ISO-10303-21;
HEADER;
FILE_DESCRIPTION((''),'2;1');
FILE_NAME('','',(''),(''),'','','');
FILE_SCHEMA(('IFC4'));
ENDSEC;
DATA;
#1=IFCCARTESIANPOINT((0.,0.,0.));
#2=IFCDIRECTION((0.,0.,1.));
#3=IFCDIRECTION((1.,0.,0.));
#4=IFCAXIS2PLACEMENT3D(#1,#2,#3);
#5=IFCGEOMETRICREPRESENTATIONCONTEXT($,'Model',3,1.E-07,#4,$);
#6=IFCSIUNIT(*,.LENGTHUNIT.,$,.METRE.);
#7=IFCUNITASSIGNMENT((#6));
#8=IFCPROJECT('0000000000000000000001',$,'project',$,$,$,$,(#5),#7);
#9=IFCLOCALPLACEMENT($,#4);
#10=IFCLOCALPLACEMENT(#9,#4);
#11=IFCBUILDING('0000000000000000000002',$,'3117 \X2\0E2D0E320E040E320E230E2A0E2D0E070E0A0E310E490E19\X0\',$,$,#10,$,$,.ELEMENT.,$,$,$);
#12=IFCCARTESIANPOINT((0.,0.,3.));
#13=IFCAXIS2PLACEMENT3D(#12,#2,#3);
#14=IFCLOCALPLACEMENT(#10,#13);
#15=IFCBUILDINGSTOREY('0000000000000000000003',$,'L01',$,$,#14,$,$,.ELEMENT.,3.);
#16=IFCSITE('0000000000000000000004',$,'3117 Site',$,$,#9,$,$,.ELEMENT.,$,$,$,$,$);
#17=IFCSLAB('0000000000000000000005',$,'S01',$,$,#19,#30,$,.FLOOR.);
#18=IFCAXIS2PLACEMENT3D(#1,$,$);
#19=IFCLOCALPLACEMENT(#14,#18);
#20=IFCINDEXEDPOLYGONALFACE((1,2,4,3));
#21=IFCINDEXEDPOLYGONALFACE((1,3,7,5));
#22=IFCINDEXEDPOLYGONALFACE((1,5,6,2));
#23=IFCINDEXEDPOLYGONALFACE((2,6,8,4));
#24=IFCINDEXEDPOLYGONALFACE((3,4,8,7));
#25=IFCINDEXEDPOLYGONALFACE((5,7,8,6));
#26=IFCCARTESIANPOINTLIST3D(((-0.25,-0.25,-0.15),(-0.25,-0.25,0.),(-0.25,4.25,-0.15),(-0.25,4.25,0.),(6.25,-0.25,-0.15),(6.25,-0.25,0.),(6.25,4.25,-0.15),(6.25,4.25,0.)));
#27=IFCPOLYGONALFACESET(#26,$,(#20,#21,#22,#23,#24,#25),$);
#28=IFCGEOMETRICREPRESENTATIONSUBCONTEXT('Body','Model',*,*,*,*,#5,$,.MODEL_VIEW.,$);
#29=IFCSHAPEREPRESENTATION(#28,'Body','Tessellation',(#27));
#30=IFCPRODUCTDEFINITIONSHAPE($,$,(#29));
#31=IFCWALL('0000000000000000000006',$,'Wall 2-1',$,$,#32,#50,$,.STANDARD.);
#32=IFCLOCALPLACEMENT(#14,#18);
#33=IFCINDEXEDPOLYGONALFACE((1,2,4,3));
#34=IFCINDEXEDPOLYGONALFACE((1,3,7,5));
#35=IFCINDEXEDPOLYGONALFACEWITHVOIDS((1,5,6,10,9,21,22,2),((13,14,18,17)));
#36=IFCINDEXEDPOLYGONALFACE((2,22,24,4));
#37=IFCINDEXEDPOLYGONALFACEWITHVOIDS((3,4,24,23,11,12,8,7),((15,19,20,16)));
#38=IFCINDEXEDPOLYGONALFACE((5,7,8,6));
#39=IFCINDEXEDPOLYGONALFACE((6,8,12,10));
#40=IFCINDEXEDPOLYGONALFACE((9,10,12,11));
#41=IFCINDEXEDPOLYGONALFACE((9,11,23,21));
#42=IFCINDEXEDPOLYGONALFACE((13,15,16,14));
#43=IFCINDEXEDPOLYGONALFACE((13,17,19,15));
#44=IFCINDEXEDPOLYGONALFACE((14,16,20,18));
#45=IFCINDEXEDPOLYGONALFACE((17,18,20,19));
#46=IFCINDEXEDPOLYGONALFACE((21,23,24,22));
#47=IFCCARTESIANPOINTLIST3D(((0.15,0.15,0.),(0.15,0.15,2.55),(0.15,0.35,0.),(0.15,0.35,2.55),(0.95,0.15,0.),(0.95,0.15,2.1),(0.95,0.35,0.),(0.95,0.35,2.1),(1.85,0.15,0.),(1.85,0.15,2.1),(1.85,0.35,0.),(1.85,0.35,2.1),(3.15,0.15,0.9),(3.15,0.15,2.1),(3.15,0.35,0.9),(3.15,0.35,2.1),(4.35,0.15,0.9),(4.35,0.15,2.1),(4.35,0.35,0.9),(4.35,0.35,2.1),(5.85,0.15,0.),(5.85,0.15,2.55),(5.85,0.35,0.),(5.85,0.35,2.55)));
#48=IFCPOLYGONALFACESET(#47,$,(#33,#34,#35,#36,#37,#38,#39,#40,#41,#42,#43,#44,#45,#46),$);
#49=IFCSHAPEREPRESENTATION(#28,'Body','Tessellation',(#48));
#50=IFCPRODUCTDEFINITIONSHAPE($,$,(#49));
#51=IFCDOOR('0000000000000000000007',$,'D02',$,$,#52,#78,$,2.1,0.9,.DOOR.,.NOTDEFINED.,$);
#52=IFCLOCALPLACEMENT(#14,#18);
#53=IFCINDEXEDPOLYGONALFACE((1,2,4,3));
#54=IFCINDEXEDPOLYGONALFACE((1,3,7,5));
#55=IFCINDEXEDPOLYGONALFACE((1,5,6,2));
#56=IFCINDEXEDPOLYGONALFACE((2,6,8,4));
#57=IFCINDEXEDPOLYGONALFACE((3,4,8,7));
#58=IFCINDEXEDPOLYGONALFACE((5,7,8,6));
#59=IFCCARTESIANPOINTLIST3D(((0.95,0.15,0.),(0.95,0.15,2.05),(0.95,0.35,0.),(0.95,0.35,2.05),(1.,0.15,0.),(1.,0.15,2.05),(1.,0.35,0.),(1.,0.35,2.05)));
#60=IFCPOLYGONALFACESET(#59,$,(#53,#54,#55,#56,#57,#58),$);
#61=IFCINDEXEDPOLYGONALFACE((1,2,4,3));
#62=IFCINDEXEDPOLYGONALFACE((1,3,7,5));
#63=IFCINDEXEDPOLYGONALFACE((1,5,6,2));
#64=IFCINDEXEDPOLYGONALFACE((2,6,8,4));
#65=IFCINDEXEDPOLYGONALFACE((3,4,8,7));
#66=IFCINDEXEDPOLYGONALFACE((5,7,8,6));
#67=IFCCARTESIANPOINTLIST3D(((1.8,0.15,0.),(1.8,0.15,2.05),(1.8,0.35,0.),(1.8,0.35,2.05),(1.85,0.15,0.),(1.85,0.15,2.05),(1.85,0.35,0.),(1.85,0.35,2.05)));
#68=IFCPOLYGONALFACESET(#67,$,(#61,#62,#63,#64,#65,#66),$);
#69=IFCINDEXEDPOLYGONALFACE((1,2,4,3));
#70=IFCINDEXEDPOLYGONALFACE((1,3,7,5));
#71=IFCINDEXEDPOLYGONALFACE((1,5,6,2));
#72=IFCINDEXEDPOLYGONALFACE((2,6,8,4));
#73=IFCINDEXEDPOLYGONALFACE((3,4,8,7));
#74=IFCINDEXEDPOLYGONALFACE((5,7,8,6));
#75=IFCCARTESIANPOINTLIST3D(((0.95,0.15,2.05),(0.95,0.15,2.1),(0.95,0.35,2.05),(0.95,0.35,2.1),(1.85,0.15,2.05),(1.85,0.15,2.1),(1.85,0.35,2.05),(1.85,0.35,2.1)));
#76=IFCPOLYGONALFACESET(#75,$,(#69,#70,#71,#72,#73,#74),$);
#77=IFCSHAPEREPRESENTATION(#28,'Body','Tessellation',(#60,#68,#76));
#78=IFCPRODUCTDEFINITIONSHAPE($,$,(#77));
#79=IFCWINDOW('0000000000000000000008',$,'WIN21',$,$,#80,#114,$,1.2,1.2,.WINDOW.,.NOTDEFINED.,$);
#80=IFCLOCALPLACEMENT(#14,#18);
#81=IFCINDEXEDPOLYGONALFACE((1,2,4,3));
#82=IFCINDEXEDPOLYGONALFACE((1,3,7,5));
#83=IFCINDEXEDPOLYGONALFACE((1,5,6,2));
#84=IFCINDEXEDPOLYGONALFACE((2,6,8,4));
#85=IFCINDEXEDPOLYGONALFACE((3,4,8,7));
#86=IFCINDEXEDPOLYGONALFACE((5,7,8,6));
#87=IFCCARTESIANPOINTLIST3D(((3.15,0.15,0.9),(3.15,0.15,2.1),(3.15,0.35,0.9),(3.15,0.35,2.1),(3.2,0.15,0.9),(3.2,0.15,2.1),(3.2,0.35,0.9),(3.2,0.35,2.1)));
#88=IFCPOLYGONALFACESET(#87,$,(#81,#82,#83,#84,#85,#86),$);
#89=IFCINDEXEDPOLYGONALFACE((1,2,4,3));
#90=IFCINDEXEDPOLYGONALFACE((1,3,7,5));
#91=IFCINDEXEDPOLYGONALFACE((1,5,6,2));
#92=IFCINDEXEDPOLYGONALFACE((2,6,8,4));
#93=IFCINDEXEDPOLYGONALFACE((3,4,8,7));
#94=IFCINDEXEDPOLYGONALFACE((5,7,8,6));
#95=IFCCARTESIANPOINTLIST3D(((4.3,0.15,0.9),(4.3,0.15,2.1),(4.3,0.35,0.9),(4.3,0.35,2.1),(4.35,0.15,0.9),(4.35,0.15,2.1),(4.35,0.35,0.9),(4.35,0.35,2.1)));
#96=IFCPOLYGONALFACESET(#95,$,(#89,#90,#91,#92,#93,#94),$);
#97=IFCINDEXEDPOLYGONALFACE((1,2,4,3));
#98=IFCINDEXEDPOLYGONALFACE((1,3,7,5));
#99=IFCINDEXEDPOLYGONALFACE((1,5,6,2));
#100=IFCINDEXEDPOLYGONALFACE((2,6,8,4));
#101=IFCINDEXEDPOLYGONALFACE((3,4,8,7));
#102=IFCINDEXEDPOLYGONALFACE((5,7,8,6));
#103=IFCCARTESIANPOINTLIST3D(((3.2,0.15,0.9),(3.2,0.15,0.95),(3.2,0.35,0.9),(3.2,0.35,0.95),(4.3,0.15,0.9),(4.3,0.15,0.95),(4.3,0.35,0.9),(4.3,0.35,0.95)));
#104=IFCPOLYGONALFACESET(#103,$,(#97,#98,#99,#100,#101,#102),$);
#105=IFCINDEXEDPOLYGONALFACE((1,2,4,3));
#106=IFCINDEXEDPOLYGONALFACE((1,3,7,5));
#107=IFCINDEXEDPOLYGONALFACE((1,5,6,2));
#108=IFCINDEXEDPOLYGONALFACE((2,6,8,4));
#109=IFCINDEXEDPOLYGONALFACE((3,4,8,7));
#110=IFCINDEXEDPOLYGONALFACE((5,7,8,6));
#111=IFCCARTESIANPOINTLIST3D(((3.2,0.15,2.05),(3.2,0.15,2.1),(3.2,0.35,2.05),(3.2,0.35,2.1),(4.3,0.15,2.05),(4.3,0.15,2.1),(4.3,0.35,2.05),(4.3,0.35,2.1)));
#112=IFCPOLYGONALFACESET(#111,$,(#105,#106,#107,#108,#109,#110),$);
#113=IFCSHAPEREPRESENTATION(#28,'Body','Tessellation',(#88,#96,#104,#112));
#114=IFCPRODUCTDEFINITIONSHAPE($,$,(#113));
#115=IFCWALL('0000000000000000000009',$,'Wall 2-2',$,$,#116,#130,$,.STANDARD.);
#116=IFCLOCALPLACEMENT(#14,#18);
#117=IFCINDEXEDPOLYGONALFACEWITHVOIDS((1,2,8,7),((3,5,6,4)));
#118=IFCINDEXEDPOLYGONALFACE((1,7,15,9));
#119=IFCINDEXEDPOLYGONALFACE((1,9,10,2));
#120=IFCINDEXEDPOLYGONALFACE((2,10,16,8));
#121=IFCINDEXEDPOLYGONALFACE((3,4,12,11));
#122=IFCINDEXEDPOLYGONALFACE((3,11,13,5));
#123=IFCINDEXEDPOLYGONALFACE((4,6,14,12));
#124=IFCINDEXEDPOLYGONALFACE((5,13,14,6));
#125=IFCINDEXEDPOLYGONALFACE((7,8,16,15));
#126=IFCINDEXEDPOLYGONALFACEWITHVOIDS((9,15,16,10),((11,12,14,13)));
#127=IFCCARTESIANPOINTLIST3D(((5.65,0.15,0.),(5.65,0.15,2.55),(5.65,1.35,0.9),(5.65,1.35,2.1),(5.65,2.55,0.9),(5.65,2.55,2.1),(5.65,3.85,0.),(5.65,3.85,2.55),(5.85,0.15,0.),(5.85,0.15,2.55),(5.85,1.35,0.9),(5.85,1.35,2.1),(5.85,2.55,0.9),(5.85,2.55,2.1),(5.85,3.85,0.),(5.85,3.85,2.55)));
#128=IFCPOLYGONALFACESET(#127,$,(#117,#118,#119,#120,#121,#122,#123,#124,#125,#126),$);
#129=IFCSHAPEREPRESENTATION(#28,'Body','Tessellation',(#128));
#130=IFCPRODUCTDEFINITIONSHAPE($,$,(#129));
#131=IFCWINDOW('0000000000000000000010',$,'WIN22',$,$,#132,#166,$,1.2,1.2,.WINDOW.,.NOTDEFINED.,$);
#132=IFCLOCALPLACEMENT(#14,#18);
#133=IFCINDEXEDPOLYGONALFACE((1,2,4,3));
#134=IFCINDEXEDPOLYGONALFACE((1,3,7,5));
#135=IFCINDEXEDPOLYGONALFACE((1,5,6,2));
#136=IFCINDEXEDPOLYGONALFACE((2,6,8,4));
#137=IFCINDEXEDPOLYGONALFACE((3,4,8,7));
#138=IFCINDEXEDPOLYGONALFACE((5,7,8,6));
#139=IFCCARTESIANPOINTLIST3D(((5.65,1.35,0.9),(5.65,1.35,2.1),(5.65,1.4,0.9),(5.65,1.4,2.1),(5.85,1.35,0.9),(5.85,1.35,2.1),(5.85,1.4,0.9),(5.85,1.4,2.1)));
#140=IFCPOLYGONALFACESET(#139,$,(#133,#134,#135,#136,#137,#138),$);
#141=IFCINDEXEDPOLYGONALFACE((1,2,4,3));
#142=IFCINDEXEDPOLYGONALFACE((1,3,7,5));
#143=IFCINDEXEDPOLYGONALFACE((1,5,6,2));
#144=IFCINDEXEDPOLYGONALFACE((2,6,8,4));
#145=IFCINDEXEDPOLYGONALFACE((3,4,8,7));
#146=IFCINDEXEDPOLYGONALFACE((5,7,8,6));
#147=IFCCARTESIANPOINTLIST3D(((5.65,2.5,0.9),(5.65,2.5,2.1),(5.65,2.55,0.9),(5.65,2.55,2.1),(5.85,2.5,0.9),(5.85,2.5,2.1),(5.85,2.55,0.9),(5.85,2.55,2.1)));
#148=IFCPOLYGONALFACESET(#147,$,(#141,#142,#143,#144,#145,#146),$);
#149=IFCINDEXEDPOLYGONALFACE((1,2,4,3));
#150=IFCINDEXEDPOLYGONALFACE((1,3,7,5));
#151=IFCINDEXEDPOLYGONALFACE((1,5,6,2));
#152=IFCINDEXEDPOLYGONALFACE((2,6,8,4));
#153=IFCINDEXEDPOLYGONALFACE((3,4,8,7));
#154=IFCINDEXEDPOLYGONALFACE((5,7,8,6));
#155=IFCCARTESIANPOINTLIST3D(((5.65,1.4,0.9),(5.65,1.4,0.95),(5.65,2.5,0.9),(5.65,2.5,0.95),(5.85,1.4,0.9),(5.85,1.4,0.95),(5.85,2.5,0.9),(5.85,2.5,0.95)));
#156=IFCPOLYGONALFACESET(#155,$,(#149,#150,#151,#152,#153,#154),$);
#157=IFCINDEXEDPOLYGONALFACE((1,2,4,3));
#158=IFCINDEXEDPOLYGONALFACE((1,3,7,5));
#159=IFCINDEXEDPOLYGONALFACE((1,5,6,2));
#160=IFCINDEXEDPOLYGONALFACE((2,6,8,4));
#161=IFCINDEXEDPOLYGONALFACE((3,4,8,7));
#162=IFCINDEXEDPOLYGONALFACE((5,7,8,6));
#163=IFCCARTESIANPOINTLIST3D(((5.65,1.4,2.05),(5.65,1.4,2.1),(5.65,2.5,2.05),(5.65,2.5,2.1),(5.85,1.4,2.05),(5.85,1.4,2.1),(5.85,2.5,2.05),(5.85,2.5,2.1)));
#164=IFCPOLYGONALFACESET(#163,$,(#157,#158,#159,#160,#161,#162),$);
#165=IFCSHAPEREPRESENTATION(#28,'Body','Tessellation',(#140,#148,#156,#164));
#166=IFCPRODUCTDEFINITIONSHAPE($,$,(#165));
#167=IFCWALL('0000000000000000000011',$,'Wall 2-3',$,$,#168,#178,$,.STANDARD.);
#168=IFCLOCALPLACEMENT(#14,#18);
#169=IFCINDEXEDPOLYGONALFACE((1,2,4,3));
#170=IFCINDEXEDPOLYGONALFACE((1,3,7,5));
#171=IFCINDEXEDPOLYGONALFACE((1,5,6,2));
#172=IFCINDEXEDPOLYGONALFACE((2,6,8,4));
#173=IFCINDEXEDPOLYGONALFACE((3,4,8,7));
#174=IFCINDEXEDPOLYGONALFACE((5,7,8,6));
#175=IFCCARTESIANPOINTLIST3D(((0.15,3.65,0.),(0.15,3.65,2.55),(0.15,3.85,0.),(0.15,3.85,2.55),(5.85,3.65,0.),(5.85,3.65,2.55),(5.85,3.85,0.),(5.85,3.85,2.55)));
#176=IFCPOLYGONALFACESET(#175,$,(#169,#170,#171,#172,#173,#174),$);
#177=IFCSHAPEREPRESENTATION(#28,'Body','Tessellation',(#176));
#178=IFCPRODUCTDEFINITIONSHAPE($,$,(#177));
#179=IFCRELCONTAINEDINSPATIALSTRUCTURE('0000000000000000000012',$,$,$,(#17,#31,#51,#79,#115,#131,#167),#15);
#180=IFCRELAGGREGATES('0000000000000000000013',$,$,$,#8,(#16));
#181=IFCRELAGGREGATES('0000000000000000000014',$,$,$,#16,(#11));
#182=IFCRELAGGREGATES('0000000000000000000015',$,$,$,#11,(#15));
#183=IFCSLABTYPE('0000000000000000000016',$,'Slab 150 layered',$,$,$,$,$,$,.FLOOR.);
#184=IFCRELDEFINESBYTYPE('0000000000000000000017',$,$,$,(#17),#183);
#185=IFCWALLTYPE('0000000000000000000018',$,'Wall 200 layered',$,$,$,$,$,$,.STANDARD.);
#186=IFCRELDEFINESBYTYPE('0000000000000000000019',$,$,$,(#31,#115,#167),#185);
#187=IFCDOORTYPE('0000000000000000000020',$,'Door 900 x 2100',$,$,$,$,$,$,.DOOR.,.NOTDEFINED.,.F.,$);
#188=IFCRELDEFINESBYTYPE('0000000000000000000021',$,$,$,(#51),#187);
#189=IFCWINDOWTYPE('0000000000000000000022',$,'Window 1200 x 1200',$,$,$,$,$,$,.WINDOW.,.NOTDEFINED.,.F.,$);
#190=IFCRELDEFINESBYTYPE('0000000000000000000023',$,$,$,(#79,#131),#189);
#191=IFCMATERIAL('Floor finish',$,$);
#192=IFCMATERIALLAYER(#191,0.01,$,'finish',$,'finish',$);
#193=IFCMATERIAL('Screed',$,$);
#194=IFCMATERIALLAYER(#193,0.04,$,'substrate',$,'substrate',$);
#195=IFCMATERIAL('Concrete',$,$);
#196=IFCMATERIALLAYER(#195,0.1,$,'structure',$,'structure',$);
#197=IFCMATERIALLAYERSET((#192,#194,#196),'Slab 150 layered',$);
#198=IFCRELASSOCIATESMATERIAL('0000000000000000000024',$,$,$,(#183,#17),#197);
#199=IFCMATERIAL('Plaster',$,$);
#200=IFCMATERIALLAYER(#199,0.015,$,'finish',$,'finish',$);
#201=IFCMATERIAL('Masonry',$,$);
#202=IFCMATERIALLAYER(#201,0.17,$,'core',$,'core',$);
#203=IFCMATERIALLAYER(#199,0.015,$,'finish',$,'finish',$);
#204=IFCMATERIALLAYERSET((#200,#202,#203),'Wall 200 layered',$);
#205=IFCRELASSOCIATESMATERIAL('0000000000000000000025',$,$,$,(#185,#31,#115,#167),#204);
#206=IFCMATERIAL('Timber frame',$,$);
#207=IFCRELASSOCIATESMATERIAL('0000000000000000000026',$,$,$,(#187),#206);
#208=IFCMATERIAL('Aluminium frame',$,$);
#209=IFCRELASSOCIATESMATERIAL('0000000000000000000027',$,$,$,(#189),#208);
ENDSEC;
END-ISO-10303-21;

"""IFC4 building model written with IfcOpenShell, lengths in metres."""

from ifc_helpers import new_model, si_unit, frame, origin_with_axes, place, context, subcontext, project, spatial, polyline, outline, extrude, material, layer, layer_set, layer_usage, type_object, element, fill, save


model = new_model("IFC4")

# Units and contexts
model_context = context("Model", 3, precision=1e-07, world=origin_with_axes())
body_context = subcontext(model_context, "Body", "Model", "MODEL_VIEW")
ifc_project = project(units=[si_unit("LENGTHUNIT", "METRE")], contexts=[model_context])

# Site, building, storey
site_placement = place(None, origin_with_axes())
site = spatial("IfcSite", under=ifc_project, at=site_placement, Name="3117 Site", CompositionType="ELEMENT")
building_placement = place(site_placement, origin_with_axes())
building = spatial("IfcBuilding", under=site, at=building_placement, Name="3117 อาคารสองชั้น", CompositionType="ELEMENT")
storey_placement = place(building_placement, frame((0.0, 0.0, 3.0), z_axis=(0.0, 0.0, 1.0), x_axis=(1.0, 0.0, 0.0)))
storey = spatial("IfcBuildingStorey", under=building, at=storey_placement, Name="L01", CompositionType="ELEMENT", Elevation=3.0)

# Shared definitions
ifc_material_1 = material(Name="Concrete")

# Slab
ifc_material_2 = material(Name="Floor finish")
ifc_layer_1 = layer(ifc_material_2, 0.01, Name="finish", Category="finish")
ifc_material_3 = material(Name="Screed")
ifc_layer_2 = layer(ifc_material_3, 0.04, Name="substrate", Category="substrate")
ifc_layer_3 = layer(ifc_material_1, 0.1, Name="structure", Category="structure")
ifc_layer_set_1 = layer_set([ifc_layer_1, ifc_layer_2, ifc_layer_3], Name="Slab 150 layered")
ifc_layer_usage_1 = layer_usage(ifc_layer_set_1, "AXIS3", "NEGATIVE", 0.15)
slab_type = type_object("IfcSlabType", Name="Slab 150 layered", PredefinedType="FLOOR", material=ifc_layer_set_1)
slab_placement = place(storey_placement, frame((0.0, 0.0, -0.15), z_axis=(0.0, 0.0, 1.0), x_axis=(1.0, 0.0, 0.0)))
element("IfcSlab", 1, at=slab_placement, inside=storey, type_object=slab_type, material=ifc_layer_usage_1, Name="S01", PredefinedType="FLOOR", context=body_context, shape_type="SweptSolid", body=[
    extrude(outline(polyline([(-0.25, -0.25), (6.25, -0.25), (6.25, 4.25), (-0.25, 4.25), (-0.25, -0.25)])), origin_with_axes(), (0.0, 0.0, 1.0), 0.15),
])

# Wall, openings, door, window
ifc_material_4 = material(Name="Plaster")
ifc_layer_4 = layer(ifc_material_4, 0.015, Name="finish", Category="finish")
ifc_material_5 = material(Name="Masonry")
ifc_layer_5 = layer(ifc_material_5, 0.17, Name="core", Category="core")
ifc_layer_6 = layer(ifc_material_4, 0.015, Name="finish", Category="finish")
ifc_layer_set_2 = layer_set([ifc_layer_4, ifc_layer_5, ifc_layer_6], Name="Wall 200 layered")
ifc_layer_usage_2 = layer_usage(ifc_layer_set_2, "AXIS2", "POSITIVE", 0.0)
wall_type = type_object("IfcWallType", Name="Wall 200 layered", PredefinedType="STANDARD", material=ifc_layer_set_2)
wall_1_placement = place(storey_placement, frame((0.15, 0.15, 0.0), z_axis=(0.0, 0.0, 1.0), x_axis=(1.0, 0.0, 0.0)))
wall_1 = element("IfcWall", 2, at=wall_1_placement, inside=storey, type_object=wall_type, material=ifc_layer_usage_2, Name="Wall 2-1", PredefinedType="STANDARD", context=body_context, shape_type="SweptSolid", body=[
    extrude(outline(polyline([(0.0, 0.0), (5.7, 0.0), (5.7, 0.2), (0.0, 0.2), (0.0, 0.0)])), origin_with_axes(), (0.0, 0.0, 1.0), 2.55),
])
opening_1_placement = place(wall_1_placement, frame((3.0, 0.0, 0.9), z_axis=(0.0, 0.0, 1.0), x_axis=(1.0, 0.0, 0.0)))
opening_1 = element("IfcOpeningElement", 3, at=opening_1_placement, cuts=wall_1, PredefinedType="OPENING", context=body_context, shape_type="SweptSolid", body=[
    extrude(outline(polyline([(0.0, 0.0), (1.2, 0.0), (1.2, 0.2), (0.0, 0.2), (0.0, 0.0)])), origin_with_axes(), (0.0, 0.0, 1.0), 1.2),
])
opening_2_placement = place(wall_1_placement, frame((0.8, 0.0, 0.0), z_axis=(0.0, 0.0, 1.0), x_axis=(1.0, 0.0, 0.0)))
opening_2 = element("IfcOpeningElement", 4, at=opening_2_placement, cuts=wall_1, PredefinedType="OPENING", context=body_context, shape_type="SweptSolid", body=[
    extrude(outline(polyline([(0.0, 0.0), (0.9, 0.0), (0.9, 0.2), (0.0, 0.2), (0.0, 0.0)])), origin_with_axes(), (0.0, 0.0, 1.0), 2.1),
])
ifc_material_6 = material(Name="Timber frame")
door_type = type_object("IfcDoorType", Name="Door 900 x 2100", OperationType="NOTDEFINED", ParameterTakesPrecedence=False, PredefinedType="DOOR", material=ifc_material_6)
door_placement = place(opening_2_placement, frame((0.0, 0.0, 0.0), z_axis=(0.0, 0.0, 1.0), x_axis=(1.0, 0.0, 0.0)))
door = element("IfcDoor", 5, at=door_placement, inside=storey, type_object=door_type, Name="D02", OperationType="NOTDEFINED", OverallHeight=2.1, OverallWidth=0.9, PredefinedType="DOOR", context=body_context, shape_type="SweptSolid", body=[
    extrude(outline(polyline([(0.0, 0.0), (0.05, 0.0), (0.05, 0.2), (0.0, 0.2), (0.0, 0.0)])), origin_with_axes(), (0.0, 0.0, 1.0), 2.05),
    extrude(outline(polyline([(0.0, 0.0), (0.05, 0.0), (0.05, 0.2), (0.0, 0.2), (0.0, 0.0)])), frame((0.85, 0.0, 0.0), z_axis=(0.0, 0.0, 1.0), x_axis=(1.0, 0.0, 0.0)), (0.0, 0.0, 1.0), 2.05),
    extrude(outline(polyline([(0.0, 0.0), (0.9, 0.0), (0.9, 0.2), (0.0, 0.2), (0.0, 0.0)])), frame((0.0, 0.0, 2.05), z_axis=(0.0, 0.0, 1.0), x_axis=(1.0, 0.0, 0.0)), (0.0, 0.0, 1.0), 0.05),
])
fill(opening_2, door)
ifc_material_7 = material(Name="Aluminium frame")
window_type = type_object("IfcWindowType", Name="Window 1200 x 1200", ParameterTakesPrecedence=False, PartitioningType="NOTDEFINED", PredefinedType="WINDOW", material=ifc_material_7)
window_1_placement = place(opening_1_placement, frame((0.0, 0.0, 0.0), z_axis=(0.0, 0.0, 1.0), x_axis=(1.0, 0.0, 0.0)))
window_1 = element("IfcWindow", 6, at=window_1_placement, inside=storey, type_object=window_type, Name="WIN21", OverallHeight=1.2, OverallWidth=1.2, PartitioningType="NOTDEFINED", PredefinedType="WINDOW", context=body_context, shape_type="SweptSolid", body=[
    extrude(outline(polyline([(0.0, 0.0), (0.05, 0.0), (0.05, 0.2), (0.0, 0.2), (0.0, 0.0)])), origin_with_axes(), (0.0, 0.0, 1.0), 1.2),
    extrude(outline(polyline([(0.0, 0.0), (0.05, 0.0), (0.05, 0.2), (0.0, 0.2), (0.0, 0.0)])), frame((1.15, 0.0, 0.0), z_axis=(0.0, 0.0, 1.0), x_axis=(1.0, 0.0, 0.0)), (0.0, 0.0, 1.0), 1.2),
    extrude(outline(polyline([(0.0, 0.0), (1.1, 0.0), (1.1, 0.2), (0.0, 0.2), (0.0, 0.0)])), frame((0.05, 0.0, 0.0), z_axis=(0.0, 0.0, 1.0), x_axis=(1.0, 0.0, 0.0)), (0.0, 0.0, 1.0), 0.05),
    extrude(outline(polyline([(0.0, 0.0), (1.1, 0.0), (1.1, 0.2), (0.0, 0.2), (0.0, 0.0)])), frame((0.05, 0.0, 1.15), z_axis=(0.0, 0.0, 1.0), x_axis=(1.0, 0.0, 0.0)), (0.0, 0.0, 1.0), 0.05),
])
fill(opening_1, window_1)

# Wall, opening, window
ifc_layer_usage_3 = layer_usage(ifc_layer_set_2, "AXIS2", "POSITIVE", 0.0)
wall_2_placement = place(storey_placement, frame((5.85, 0.15, 0.0), z_axis=(0.0, 0.0, 1.0), x_axis=(0.0, 1.0, 0.0)))
wall_2 = element("IfcWall", 7, at=wall_2_placement, inside=storey, type_object=wall_type, material=ifc_layer_usage_3, Name="Wall 2-2", PredefinedType="STANDARD", context=body_context, shape_type="SweptSolid", body=[
    extrude(outline(polyline([(0.0, 0.0), (3.7, 0.0), (3.7, 0.2), (0.0, 0.2), (0.0, 0.0)])), origin_with_axes(), (0.0, 0.0, 1.0), 2.55),
])
opening_3_placement = place(wall_2_placement, frame((1.2, 0.0, 0.9), z_axis=(0.0, 0.0, 1.0), x_axis=(1.0, 0.0, 0.0)))
opening_3 = element("IfcOpeningElement", 8, at=opening_3_placement, cuts=wall_2, PredefinedType="OPENING", context=body_context, shape_type="SweptSolid", body=[
    extrude(outline(polyline([(0.0, 0.0), (1.2, 0.0), (1.2, 0.2), (0.0, 0.2), (0.0, 0.0)])), origin_with_axes(), (0.0, 0.0, 1.0), 1.2),
])
window_2_placement = place(opening_3_placement, frame((0.0, 0.0, 0.0), z_axis=(0.0, 0.0, 1.0), x_axis=(1.0, 0.0, 0.0)))
window_2 = element("IfcWindow", 9, at=window_2_placement, inside=storey, type_object=window_type, Name="WIN22", OverallHeight=1.2, OverallWidth=1.2, PartitioningType="NOTDEFINED", PredefinedType="WINDOW", context=body_context, shape_type="SweptSolid", body=[
    extrude(outline(polyline([(0.0, 0.0), (0.05, 0.0), (0.05, 0.2), (0.0, 0.2), (0.0, 0.0)])), origin_with_axes(), (0.0, 0.0, 1.0), 1.2),
    extrude(outline(polyline([(0.0, 0.0), (0.05, 0.0), (0.05, 0.2), (0.0, 0.2), (0.0, 0.0)])), frame((1.15, 0.0, 0.0), z_axis=(0.0, 0.0, 1.0), x_axis=(1.0, 0.0, 0.0)), (0.0, 0.0, 1.0), 1.2),
    extrude(outline(polyline([(0.0, 0.0), (1.1, 0.0), (1.1, 0.2), (0.0, 0.2), (0.0, 0.0)])), frame((0.05, 0.0, 0.0), z_axis=(0.0, 0.0, 1.0), x_axis=(1.0, 0.0, 0.0)), (0.0, 0.0, 1.0), 0.05),
    extrude(outline(polyline([(0.0, 0.0), (1.1, 0.0), (1.1, 0.2), (0.0, 0.2), (0.0, 0.0)])), frame((0.05, 0.0, 1.15), z_axis=(0.0, 0.0, 1.0), x_axis=(1.0, 0.0, 0.0)), (0.0, 0.0, 1.0), 0.05),
])
fill(opening_3, window_2)

# Wall
ifc_layer_usage_4 = layer_usage(ifc_layer_set_2, "AXIS2", "POSITIVE", 0.0)
wall_3_placement = place(storey_placement, frame((5.85, 3.85, 0.0), z_axis=(0.0, 0.0, 1.0), x_axis=(-1.0, 0.0, 0.0)))
element("IfcWall", 10, at=wall_3_placement, inside=storey, type_object=wall_type, material=ifc_layer_usage_4, Name="Wall 2-3", PredefinedType="STANDARD", context=body_context, shape_type="SweptSolid", body=[
    extrude(outline(polyline([(0.0, 0.0), (5.7, 0.0), (5.7, 0.2), (0.0, 0.2), (0.0, 0.0)])), origin_with_axes(), (0.0, 0.0, 1.0), 2.55),
])

save(model, "model.ifc")
